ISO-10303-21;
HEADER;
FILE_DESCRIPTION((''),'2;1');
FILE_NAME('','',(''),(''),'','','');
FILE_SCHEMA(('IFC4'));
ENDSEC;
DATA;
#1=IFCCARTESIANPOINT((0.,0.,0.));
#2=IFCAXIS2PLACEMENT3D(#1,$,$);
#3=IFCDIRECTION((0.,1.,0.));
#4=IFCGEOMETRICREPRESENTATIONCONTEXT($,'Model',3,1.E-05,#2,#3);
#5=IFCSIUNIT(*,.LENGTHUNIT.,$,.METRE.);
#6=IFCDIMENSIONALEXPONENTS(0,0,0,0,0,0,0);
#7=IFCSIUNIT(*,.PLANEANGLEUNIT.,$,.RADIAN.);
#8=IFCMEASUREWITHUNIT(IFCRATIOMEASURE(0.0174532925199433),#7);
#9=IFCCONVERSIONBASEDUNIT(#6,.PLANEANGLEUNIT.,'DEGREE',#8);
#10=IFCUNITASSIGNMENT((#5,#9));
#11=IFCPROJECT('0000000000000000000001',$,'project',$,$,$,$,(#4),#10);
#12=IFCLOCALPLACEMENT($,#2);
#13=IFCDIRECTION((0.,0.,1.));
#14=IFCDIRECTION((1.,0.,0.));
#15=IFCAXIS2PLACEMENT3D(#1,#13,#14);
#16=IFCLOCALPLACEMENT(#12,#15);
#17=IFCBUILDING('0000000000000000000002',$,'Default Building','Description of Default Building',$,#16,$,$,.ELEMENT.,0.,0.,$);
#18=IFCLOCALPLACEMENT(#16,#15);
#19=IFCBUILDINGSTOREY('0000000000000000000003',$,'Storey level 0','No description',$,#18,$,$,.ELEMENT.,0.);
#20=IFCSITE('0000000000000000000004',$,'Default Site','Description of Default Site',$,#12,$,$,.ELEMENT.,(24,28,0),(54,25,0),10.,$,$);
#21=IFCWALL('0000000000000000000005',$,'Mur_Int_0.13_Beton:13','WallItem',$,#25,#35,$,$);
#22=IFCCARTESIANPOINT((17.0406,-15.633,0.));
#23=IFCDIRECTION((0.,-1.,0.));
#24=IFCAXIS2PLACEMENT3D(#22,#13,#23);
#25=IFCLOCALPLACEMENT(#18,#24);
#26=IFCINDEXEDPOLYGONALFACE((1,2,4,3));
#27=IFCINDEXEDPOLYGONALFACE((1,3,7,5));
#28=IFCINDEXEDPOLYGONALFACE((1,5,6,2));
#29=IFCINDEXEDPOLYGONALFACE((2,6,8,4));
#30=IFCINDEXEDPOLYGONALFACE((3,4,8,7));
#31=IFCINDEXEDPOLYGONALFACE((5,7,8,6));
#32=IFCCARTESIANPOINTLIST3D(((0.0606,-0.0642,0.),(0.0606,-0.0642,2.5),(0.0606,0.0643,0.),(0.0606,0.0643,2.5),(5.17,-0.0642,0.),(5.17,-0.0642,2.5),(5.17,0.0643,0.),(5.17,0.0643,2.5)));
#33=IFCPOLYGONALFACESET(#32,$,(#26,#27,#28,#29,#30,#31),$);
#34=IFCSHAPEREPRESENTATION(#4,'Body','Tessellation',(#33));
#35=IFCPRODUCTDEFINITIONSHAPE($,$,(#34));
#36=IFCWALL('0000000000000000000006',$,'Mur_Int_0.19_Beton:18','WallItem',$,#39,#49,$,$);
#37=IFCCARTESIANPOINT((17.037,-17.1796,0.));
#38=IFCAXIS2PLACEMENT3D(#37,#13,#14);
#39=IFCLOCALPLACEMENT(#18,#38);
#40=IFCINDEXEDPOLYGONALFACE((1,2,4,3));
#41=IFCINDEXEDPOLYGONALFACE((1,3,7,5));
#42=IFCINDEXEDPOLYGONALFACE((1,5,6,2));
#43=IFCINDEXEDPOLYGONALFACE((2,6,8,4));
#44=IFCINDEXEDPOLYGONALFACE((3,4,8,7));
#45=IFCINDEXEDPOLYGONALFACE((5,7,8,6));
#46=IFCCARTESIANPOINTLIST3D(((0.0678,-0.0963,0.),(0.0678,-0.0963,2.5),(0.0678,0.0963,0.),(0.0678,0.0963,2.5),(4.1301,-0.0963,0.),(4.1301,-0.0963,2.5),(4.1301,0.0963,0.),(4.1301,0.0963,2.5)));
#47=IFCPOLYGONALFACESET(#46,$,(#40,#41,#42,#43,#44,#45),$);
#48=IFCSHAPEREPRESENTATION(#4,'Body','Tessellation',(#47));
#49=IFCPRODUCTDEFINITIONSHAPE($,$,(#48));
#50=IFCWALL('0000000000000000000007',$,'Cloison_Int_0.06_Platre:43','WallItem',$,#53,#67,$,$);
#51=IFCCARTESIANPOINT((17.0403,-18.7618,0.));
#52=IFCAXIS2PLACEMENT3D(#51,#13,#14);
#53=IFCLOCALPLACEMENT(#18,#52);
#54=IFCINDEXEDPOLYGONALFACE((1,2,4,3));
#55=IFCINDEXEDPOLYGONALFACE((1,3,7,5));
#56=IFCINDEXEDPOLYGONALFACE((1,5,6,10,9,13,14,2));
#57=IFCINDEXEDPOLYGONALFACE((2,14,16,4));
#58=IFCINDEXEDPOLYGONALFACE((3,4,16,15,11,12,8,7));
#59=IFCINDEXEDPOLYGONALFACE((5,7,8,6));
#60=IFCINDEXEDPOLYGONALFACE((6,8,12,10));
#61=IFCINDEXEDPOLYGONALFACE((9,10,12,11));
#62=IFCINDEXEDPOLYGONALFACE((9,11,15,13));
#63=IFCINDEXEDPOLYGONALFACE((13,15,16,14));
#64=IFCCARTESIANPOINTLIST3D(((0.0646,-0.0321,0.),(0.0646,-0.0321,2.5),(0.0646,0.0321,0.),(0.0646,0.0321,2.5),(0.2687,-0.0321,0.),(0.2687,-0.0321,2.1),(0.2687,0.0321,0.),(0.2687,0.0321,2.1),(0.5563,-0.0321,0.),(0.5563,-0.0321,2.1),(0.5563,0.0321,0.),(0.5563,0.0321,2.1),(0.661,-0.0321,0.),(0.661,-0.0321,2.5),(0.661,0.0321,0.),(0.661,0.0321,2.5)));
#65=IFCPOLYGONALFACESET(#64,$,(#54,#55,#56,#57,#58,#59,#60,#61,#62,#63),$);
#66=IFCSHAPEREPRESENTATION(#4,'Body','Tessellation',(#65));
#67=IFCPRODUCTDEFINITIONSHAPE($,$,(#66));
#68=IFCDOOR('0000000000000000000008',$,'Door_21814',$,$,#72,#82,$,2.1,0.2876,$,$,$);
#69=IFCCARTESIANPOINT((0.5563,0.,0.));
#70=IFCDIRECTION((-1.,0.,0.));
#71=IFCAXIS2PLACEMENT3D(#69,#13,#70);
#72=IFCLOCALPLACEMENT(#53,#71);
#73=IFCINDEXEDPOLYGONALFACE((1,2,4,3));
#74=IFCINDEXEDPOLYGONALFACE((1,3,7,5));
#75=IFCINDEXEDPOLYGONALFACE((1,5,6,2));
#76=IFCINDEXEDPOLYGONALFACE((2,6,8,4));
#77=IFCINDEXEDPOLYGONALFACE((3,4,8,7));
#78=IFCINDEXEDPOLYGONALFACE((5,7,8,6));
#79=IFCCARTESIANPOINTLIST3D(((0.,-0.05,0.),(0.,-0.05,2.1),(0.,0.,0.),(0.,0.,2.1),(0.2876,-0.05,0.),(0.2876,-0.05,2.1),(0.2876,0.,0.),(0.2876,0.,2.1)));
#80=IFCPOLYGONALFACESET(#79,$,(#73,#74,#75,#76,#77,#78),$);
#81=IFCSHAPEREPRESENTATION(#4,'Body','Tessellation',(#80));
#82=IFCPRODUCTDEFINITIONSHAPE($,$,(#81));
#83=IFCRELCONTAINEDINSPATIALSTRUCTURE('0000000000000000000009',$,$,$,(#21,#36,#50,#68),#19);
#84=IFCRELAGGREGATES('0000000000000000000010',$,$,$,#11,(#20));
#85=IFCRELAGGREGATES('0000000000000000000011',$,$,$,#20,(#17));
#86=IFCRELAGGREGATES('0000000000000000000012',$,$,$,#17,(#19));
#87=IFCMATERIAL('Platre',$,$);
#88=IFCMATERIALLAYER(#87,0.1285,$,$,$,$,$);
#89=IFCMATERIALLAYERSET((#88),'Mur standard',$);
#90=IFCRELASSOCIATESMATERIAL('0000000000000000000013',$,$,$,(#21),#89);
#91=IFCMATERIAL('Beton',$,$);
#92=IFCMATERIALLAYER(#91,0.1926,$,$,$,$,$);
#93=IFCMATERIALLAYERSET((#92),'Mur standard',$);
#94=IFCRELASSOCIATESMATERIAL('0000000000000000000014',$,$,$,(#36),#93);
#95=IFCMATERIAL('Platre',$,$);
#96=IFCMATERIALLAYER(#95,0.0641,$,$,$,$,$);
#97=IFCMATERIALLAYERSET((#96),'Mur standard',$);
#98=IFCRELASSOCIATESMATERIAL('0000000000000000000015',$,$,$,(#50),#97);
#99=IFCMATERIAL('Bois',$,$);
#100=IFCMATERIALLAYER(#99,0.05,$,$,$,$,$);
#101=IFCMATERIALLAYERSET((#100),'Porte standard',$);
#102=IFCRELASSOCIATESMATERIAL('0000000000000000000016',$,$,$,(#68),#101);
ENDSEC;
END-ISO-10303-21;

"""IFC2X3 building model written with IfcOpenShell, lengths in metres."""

from ifc_helpers import new_model, entity, si_unit, converted_unit, direction, frame, origin, origin_with_axes, place, context, project, spatial, polyline, outline, extrude, material, layer, layer_set, layer_usage, element, fill, save


model = new_model("IFC2X3")

# Units and contexts
model_context = context("Model", 3, precision=1e-05, world=origin(), true_north=direction((0.0, 1.0, 0.0)))
ifc_project = project(units=[si_unit("LENGTHUNIT", "METRE"), converted_unit("PLANEANGLEUNIT", "DEGREE", entity("IfcRatioMeasure", 0.0174532925199433), si_unit("PLANEANGLEUNIT", "RADIAN"), dimensions=[0, 0, 0, 0, 0, 0, 0])], contexts=[model_context])

# Site, building, storey
site_placement = place(None, origin())
site = spatial("IfcSite", under=ifc_project, at=site_placement, Name="Default Site", Description="Description of Default Site", CompositionType="ELEMENT", RefLatitude=(24, 28, 0), RefLongitude=(54, 25, 0), RefElevation=10.0)
building_placement = place(site_placement, origin_with_axes())
building = spatial("IfcBuilding", under=site, at=building_placement, Name="Default Building", Description="Description of Default Building", CompositionType="ELEMENT", ElevationOfRefHeight=0.0, ElevationOfTerrain=0.0)
storey_placement = place(building_placement, origin_with_axes())
storey = spatial("IfcBuildingStorey", under=building, at=storey_placement, Name="Storey level 0", Description="No description", CompositionType="ELEMENT", Elevation=0.0)

# Shared definitions
ifc_material_1 = material(Name="Bois")
ifc_layer_1 = layer(ifc_material_1, 0.05)
ifc_layer_set_1 = layer_set([ifc_layer_1], Name="Porte standard")
ifc_layer_usage_1 = layer_usage(ifc_layer_set_1, "AXIS2", "NEGATIVE", 0.05)

# Walls
ifc_material_2 = material(Name="Platre")
ifc_layer_2 = layer(ifc_material_2, 0.1285)
ifc_layer_set_2 = layer_set([ifc_layer_2], Name="Mur standard")
ifc_layer_usage_2 = layer_usage(ifc_layer_set_2, "AXIS2", "NEGATIVE", 0.1285)
wall_1_placement = place(storey_placement, frame((17.0406, -15.633, 0.0), z_axis=(0.0, 0.0, 1.0), x_axis=(0.0, -1.0, 0.0)))
element("IfcWall", 1, at=wall_1_placement, inside=storey, material=ifc_layer_usage_2, Name="Mur_Int_0.13_Beton:13", Description="WallItem", context=model_context, shape_type="SweptSolid", body=[
    extrude(outline(polyline([(0.0606, -0.0642), (5.17, -0.0642), (5.17, 0.0643), (0.0606, 0.0643), (0.0606, -0.0642)])), origin(), (0.0, 0.0, 1.0), 2.5),
])
ifc_material_3 = material(Name="Beton")
ifc_layer_3 = layer(ifc_material_3, 0.1926)
ifc_layer_set_3 = layer_set([ifc_layer_3], Name="Mur standard")
ifc_layer_usage_3 = layer_usage(ifc_layer_set_3, "AXIS2", "NEGATIVE", 0.1926)
wall_2_placement = place(storey_placement, frame((17.037, -17.1796, 0.0), z_axis=(0.0, 0.0, 1.0), x_axis=(1.0, 0.0, 0.0)))
element("IfcWall", 2, at=wall_2_placement, inside=storey, material=ifc_layer_usage_3, Name="Mur_Int_0.19_Beton:18", Description="WallItem", context=model_context, shape_type="SweptSolid", body=[
    extrude(outline(polyline([(0.0678, 0.0963), (0.0678, -0.0963), (4.1301, -0.0963), (4.1301, 0.0963), (0.0678, 0.0963)])), origin(), (0.0, 0.0, 1.0), 2.5),
])

# Wall, opening, door
ifc_material_4 = material(Name="Platre")
ifc_layer_4 = layer(ifc_material_4, 0.0641)
ifc_layer_set_4 = layer_set([ifc_layer_4], Name="Mur standard")
ifc_layer_usage_4 = layer_usage(ifc_layer_set_4, "AXIS2", "NEGATIVE", 0.0641)
wall_3_placement = place(storey_placement, frame((17.0403, -18.7618, 0.0), z_axis=(0.0, 0.0, 1.0), x_axis=(1.0, 0.0, 0.0)))
wall_3 = element("IfcWall", 3, at=wall_3_placement, inside=storey, material=ifc_layer_usage_4, Name="Cloison_Int_0.06_Platre:43", Description="WallItem", context=model_context, shape_type="SweptSolid", body=[
    extrude(outline(polyline([(0.0646, 0.0321), (0.0646, -0.0321), (0.661, -0.0321), (0.661, 0.0321), (0.0646, 0.0321)])), origin(), (0.0, 0.0, 1.0), 2.5),
])
opening_1_placement = place(storey_placement, frame((17.5966, -18.7297, 0.0), z_axis=(0.0, 0.0, 1.0), x_axis=(-1.0, 0.0, 0.0)))
opening_1 = element("IfcOpeningElement", 4, at=opening_1_placement, cuts=wall_3, context=model_context, shape_type="SweptSolid", body=[
    extrude(outline(polyline([(0.2876, 0.1141), (0.0, 0.1141), (0.0, -0.05), (0.2876, -0.05), (0.2876, 0.1141)])), origin(), (0.0, 0.0, 1.0), 2.1),
])
door_1_placement = place(wall_3_placement, frame((0.5563, 0.0, 0.0), z_axis=(0.0, 0.0, 1.0), x_axis=(-1.0, 0.0, 0.0)))
door_1 = element("IfcDoor", 5, at=door_1_placement, inside=storey, material=ifc_layer_usage_1, Name="Door_21814", OverallHeight=2.1, OverallWidth=0.2876, context=model_context, shape_type="SweptSolid", body=[
    extrude(outline(polyline([(0.0, 0.0), (0.2876, 0.0), (0.2876, -0.05), (0.0, -0.05), (0.0, 0.0)])), origin(), (0.0, 0.0, 1.0), 2.1),
])
fill(opening_1, door_1)

save(model, "model.ifc")
